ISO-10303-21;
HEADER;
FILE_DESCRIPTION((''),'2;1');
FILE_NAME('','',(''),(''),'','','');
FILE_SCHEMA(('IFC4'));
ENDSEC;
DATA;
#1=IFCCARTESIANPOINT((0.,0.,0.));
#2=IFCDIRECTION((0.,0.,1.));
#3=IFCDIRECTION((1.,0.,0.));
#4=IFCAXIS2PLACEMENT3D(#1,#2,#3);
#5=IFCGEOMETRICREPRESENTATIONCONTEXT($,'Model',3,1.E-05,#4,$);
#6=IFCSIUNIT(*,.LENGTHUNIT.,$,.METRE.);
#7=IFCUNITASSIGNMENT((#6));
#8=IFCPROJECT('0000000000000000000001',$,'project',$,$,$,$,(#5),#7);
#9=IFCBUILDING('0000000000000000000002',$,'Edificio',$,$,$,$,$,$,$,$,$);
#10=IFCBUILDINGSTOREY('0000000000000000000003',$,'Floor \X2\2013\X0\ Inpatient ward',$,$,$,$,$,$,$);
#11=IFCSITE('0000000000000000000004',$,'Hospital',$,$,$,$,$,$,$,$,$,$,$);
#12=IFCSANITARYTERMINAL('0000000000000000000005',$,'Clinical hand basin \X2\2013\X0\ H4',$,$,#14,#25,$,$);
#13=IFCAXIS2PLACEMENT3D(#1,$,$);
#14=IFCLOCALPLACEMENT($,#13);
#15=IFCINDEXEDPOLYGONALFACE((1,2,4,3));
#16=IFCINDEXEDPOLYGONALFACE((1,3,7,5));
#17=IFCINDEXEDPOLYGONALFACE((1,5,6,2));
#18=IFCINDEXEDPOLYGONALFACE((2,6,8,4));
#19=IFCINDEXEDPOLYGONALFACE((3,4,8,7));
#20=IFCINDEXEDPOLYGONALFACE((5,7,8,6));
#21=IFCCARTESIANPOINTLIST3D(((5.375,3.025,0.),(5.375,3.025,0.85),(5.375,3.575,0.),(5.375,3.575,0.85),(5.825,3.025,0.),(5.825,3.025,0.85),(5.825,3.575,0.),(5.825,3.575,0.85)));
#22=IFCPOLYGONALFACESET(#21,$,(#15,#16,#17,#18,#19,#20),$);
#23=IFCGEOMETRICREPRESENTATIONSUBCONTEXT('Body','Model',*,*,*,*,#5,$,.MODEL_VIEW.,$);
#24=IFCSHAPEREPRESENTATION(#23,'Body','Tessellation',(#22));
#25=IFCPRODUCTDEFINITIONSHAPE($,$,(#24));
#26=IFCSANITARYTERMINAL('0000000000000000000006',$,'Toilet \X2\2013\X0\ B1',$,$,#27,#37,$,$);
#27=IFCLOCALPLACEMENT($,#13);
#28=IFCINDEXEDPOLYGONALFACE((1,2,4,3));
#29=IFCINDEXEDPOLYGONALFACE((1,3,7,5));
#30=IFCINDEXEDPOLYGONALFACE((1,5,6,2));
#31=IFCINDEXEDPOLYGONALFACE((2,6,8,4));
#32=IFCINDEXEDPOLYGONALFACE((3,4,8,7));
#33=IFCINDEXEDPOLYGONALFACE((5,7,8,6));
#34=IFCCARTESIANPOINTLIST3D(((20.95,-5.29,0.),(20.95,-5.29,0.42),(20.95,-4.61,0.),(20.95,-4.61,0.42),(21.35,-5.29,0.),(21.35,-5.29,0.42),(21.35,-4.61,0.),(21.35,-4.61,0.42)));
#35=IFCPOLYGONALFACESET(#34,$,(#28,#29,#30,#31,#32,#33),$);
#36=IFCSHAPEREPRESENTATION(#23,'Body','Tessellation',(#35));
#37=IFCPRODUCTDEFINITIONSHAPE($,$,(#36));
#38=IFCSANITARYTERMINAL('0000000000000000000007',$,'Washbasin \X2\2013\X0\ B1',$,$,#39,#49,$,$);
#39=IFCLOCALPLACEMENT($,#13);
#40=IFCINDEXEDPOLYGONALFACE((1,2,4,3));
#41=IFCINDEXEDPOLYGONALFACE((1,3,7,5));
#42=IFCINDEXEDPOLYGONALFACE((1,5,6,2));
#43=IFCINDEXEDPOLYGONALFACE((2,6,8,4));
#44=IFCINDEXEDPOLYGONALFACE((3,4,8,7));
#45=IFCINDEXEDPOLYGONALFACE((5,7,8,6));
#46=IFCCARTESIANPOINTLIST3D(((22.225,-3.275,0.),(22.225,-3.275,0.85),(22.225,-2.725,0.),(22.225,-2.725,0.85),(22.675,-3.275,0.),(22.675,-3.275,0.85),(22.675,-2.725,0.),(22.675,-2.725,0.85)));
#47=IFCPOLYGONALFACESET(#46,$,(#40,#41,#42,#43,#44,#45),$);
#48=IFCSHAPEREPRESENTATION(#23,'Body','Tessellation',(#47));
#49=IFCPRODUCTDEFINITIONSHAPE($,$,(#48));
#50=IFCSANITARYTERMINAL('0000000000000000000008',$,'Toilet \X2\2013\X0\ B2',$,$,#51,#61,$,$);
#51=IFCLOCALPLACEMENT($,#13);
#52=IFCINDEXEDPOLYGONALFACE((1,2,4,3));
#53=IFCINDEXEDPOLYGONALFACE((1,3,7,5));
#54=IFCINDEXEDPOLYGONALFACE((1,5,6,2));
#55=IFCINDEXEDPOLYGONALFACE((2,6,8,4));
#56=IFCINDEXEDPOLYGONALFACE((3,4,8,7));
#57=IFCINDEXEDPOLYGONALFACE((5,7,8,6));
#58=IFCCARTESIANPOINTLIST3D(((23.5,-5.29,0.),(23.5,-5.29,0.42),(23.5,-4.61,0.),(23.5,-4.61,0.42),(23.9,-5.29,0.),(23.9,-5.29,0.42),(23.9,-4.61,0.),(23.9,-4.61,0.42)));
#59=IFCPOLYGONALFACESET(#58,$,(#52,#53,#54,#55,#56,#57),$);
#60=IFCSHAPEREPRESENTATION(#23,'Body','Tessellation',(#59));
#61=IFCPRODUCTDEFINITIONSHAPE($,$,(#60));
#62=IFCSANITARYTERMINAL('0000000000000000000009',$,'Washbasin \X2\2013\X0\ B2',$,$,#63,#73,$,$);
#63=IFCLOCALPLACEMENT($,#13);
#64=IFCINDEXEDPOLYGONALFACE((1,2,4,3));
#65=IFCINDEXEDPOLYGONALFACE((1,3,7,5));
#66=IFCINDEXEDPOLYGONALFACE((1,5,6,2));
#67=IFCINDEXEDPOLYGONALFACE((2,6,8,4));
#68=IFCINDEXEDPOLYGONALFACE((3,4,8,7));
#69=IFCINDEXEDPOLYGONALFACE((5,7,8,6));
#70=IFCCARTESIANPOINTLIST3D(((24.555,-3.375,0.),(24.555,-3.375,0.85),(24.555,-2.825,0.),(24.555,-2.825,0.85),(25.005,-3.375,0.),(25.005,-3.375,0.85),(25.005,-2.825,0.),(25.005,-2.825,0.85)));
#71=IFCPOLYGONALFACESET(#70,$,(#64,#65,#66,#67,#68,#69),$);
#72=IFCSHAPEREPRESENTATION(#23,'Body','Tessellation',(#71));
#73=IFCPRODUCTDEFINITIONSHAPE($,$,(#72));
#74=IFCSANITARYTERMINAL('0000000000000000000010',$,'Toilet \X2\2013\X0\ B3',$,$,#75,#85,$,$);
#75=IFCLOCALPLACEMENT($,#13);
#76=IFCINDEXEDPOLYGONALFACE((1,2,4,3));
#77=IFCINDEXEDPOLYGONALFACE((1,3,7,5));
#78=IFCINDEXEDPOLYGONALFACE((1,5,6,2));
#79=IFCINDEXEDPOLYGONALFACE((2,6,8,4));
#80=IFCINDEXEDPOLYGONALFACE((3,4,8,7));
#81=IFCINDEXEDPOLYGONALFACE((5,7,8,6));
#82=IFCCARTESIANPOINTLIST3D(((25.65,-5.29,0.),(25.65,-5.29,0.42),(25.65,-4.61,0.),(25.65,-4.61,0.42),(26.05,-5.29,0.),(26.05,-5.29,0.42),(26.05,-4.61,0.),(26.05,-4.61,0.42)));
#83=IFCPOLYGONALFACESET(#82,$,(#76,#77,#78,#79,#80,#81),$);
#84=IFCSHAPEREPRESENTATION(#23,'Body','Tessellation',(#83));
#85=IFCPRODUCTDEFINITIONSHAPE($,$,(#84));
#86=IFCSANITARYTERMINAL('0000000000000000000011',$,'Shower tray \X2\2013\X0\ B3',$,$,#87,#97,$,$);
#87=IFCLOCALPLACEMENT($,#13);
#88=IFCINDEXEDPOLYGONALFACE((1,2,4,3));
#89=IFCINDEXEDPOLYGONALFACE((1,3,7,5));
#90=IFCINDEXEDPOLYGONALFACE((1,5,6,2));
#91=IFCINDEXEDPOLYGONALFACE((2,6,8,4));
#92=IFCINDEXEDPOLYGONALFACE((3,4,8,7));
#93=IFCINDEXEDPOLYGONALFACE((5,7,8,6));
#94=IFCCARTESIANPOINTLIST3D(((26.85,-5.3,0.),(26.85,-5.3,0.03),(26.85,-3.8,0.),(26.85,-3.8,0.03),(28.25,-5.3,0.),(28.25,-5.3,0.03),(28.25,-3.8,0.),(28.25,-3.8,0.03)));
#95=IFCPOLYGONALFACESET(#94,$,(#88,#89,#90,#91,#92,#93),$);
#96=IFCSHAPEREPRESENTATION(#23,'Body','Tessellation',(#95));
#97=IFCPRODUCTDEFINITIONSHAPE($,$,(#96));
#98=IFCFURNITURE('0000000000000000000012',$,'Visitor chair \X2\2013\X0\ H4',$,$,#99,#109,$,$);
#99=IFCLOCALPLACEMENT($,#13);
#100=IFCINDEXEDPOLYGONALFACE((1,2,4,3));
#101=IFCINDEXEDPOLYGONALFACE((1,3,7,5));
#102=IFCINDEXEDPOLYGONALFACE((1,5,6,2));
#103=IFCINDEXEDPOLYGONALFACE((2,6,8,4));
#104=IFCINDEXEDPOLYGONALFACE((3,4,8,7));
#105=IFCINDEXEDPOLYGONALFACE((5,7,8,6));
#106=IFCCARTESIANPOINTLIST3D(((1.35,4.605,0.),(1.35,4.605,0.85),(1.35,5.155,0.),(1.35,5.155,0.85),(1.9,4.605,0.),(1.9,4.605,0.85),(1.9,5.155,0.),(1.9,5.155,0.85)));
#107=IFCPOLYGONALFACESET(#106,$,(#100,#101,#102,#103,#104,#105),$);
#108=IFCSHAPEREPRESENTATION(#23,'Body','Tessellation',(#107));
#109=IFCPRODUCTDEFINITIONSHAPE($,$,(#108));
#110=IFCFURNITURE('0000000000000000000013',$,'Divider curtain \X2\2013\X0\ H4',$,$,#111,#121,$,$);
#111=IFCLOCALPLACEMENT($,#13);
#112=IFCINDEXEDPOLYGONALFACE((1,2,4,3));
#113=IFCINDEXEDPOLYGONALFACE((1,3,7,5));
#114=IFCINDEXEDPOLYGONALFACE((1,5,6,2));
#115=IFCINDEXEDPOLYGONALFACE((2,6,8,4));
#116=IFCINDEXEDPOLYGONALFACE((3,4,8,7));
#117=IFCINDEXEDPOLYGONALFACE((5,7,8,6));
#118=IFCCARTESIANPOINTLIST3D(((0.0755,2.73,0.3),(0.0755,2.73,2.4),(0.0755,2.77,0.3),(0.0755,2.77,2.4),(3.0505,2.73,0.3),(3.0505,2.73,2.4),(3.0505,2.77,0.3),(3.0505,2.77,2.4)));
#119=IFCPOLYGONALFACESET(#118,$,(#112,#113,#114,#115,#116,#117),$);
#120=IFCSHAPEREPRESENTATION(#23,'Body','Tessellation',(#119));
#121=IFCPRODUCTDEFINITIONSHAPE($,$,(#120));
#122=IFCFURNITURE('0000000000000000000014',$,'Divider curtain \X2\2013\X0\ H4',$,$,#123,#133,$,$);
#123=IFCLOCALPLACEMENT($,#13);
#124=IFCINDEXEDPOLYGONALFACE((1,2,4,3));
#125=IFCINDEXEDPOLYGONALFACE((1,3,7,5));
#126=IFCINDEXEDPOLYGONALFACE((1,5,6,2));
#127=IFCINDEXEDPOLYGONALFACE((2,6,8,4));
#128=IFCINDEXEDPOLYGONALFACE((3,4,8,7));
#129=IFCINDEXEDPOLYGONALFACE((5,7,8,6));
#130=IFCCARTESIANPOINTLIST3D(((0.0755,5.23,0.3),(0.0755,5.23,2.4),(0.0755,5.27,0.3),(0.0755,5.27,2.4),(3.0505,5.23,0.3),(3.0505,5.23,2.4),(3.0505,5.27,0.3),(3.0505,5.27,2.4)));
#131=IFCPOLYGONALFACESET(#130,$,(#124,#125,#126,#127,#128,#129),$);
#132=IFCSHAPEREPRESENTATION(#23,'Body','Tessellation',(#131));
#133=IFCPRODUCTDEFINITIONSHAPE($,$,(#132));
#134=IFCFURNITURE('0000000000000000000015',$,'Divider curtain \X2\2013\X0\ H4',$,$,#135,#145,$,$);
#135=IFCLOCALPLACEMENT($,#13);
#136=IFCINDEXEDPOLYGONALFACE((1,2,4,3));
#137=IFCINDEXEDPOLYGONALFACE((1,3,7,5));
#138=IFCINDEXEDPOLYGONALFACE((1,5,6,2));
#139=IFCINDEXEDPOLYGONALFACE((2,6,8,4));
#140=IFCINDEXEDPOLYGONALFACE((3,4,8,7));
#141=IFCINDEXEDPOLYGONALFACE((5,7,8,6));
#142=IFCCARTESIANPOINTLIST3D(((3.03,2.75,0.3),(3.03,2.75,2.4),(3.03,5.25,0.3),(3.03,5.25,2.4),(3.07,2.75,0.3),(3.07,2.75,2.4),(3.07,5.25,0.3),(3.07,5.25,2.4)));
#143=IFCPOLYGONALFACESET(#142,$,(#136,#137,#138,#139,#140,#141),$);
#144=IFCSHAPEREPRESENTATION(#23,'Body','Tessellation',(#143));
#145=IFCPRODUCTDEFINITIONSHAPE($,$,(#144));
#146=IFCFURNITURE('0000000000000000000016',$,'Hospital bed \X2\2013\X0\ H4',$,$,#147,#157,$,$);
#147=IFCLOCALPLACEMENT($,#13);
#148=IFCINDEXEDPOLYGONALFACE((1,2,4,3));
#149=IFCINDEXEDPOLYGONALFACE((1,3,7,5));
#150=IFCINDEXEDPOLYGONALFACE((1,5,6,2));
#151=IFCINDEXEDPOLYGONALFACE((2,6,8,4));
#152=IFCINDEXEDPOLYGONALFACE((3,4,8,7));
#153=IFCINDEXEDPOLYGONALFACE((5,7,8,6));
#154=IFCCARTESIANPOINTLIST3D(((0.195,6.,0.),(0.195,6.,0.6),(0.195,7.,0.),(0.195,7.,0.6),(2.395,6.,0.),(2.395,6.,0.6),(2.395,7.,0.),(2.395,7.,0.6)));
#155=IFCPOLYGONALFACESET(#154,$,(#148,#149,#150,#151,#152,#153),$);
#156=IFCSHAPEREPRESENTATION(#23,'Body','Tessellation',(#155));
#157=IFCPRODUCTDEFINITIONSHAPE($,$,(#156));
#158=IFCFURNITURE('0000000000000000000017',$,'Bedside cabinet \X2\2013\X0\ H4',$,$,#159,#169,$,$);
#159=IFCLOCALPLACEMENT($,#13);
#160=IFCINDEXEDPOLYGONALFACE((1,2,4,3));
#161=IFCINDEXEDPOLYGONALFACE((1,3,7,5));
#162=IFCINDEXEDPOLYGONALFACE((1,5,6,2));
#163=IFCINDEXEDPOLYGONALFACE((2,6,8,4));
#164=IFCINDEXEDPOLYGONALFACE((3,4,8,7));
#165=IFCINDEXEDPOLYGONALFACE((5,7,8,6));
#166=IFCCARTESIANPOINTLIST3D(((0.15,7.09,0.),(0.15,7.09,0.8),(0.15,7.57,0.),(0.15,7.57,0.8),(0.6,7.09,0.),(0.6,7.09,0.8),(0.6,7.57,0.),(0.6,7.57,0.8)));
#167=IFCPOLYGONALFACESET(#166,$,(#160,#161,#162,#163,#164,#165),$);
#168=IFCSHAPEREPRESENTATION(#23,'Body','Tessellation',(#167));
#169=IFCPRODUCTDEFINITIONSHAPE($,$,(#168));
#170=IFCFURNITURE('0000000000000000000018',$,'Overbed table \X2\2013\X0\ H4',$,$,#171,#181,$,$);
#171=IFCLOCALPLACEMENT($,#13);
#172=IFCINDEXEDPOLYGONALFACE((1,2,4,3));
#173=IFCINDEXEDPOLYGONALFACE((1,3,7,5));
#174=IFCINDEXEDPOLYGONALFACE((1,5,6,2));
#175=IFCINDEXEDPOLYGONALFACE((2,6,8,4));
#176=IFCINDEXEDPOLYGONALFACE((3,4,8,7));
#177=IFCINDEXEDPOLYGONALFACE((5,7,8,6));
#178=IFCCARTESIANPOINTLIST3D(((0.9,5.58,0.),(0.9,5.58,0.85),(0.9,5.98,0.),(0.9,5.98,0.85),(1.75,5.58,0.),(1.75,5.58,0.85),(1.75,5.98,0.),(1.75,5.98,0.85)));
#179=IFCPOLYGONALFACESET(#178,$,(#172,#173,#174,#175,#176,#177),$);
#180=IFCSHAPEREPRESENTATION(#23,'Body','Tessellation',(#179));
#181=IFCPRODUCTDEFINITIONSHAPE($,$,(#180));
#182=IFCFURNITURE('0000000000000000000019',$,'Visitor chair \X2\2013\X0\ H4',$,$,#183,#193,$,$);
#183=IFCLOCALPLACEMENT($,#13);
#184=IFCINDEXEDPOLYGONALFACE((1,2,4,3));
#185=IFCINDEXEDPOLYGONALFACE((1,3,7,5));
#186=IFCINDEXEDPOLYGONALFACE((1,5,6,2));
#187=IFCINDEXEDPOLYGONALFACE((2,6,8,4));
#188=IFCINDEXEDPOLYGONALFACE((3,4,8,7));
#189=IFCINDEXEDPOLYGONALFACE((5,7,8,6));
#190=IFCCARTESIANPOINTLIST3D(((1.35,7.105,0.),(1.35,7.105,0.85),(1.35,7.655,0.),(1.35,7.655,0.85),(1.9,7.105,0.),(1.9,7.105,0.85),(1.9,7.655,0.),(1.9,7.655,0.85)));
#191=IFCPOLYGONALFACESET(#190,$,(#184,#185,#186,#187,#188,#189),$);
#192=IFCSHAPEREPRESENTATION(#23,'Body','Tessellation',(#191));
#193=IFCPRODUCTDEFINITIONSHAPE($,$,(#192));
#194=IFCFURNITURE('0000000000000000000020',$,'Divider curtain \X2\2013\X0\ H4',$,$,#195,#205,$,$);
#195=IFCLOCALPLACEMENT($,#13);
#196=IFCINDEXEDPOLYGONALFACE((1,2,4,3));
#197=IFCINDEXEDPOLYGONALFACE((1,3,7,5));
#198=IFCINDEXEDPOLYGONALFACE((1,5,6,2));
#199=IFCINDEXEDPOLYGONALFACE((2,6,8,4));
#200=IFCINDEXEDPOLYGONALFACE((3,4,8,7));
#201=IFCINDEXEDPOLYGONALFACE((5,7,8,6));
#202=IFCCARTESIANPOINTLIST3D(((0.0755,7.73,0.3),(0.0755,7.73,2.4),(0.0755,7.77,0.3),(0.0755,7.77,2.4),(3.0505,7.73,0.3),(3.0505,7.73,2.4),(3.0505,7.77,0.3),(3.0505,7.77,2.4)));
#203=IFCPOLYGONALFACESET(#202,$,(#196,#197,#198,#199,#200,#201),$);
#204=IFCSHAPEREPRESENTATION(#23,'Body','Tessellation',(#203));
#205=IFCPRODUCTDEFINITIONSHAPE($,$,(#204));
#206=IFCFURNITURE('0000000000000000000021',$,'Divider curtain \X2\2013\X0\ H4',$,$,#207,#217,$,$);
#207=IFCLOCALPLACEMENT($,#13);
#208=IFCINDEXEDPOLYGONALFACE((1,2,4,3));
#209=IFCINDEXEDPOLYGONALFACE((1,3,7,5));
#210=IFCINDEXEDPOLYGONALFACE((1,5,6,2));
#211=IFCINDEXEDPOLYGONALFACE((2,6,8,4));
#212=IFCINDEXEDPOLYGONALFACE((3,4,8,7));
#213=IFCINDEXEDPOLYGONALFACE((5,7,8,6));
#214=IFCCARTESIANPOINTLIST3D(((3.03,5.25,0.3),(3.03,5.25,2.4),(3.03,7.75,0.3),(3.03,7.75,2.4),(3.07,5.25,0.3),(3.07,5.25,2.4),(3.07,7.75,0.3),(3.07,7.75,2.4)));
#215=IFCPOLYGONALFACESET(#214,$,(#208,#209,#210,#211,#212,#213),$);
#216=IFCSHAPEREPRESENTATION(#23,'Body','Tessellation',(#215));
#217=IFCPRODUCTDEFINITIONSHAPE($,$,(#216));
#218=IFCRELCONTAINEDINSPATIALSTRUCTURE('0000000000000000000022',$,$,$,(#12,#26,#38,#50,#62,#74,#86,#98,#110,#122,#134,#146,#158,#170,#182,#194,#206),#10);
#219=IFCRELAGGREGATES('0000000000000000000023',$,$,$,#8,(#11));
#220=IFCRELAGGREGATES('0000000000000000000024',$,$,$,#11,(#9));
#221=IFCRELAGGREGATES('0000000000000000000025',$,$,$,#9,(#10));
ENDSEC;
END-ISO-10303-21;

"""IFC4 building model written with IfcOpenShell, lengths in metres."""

from ifc_helpers import new_model, si_unit, frame, origin_with_axes, context, subcontext, project, spatial, line, indexed_curve, outline, extrude, element, save


model = new_model("IFC4")

# Units and contexts
model_context = context("Model", 3, precision=1e-05, world=origin_with_axes())
body_context = subcontext(model_context, "Body", "Model", "MODEL_VIEW")
ifc_project = project(units=[si_unit("LENGTHUNIT", "METRE")], contexts=[model_context])

# Site, building, storey
site = spatial("IfcSite", under=ifc_project, Name="Hospital")
building = spatial("IfcBuilding", under=site, Name="Edificio")
storey = spatial("IfcBuildingStorey", under=building, Name="Floor – Inpatient ward")

# Sanitary terminals
element("IfcSanitaryTerminal", 1, inside=storey, Name="Clinical hand basin – H4", context=body_context, shape_type="SweptSolid", body=[
    extrude(outline(indexed_curve([(0.0, 0.0), (0.45, 0.0), (0.45, 0.55), (0.0, 0.55)], segments=[line(1, 2, 3, 4, 1)])), frame((5.375, 3.025, 0.0), z_axis=(0.0, 0.0, 1.0), x_axis=(1.0, 0.0, 0.0)), (0.0, 0.0, 1.0), 0.85),
])
element("IfcSanitaryTerminal", 2, inside=storey, Name="Toilet – B1", context=body_context, shape_type="SweptSolid", body=[
    extrude(outline(indexed_curve([(0.0, 0.0), (0.4, 0.0), (0.4, 0.68), (0.0, 0.68)], segments=[line(1, 2, 3, 4, 1)])), frame((20.95, -5.29, 0.0), z_axis=(0.0, 0.0, 1.0), x_axis=(1.0, 0.0, 0.0)), (0.0, 0.0, 1.0), 0.42),
])
element("IfcSanitaryTerminal", 3, inside=storey, Name="Washbasin – B1", context=body_context, shape_type="SweptSolid", body=[
    extrude(outline(indexed_curve([(0.0, 0.0), (0.45, 0.0), (0.45, 0.55), (0.0, 0.55)], segments=[line(1, 2, 3, 4, 1)])), frame((22.225, -3.275, 0.0), z_axis=(0.0, 0.0, 1.0), x_axis=(1.0, 0.0, 0.0)), (0.0, 0.0, 1.0), 0.85),
])
element("IfcSanitaryTerminal", 4, inside=storey, Name="Toilet – B2", context=body_context, shape_type="SweptSolid", body=[
    extrude(outline(indexed_curve([(0.0, 0.0), (0.4, 0.0), (0.4, 0.68), (0.0, 0.68)], segments=[line(1, 2, 3, 4, 1)])), frame((23.5, -5.29, 0.0), z_axis=(0.0, 0.0, 1.0), x_axis=(1.0, 0.0, 0.0)), (0.0, 0.0, 1.0), 0.42),
])
element("IfcSanitaryTerminal", 5, inside=storey, Name="Washbasin – B2", context=body_context, shape_type="SweptSolid", body=[
    extrude(outline(indexed_curve([(0.0, 0.0), (0.45, 0.0), (0.45, 0.55), (0.0, 0.55)], segments=[line(1, 2, 3, 4, 1)])), frame((24.555, -3.375, 0.0), z_axis=(0.0, 0.0, 1.0), x_axis=(1.0, 0.0, 0.0)), (0.0, 0.0, 1.0), 0.85),
])
element("IfcSanitaryTerminal", 6, inside=storey, Name="Toilet – B3", context=body_context, shape_type="SweptSolid", body=[
    extrude(outline(indexed_curve([(0.0, 0.0), (0.4, 0.0), (0.4, 0.68), (0.0, 0.68)], segments=[line(1, 2, 3, 4, 1)])), frame((25.65, -5.29, 0.0), z_axis=(0.0, 0.0, 1.0), x_axis=(1.0, 0.0, 0.0)), (0.0, 0.0, 1.0), 0.42),
])
element("IfcSanitaryTerminal", 7, inside=storey, Name="Shower tray – B3", context=body_context, shape_type="SweptSolid", body=[
    extrude(outline(indexed_curve([(0.0, 0.0), (1.4, 0.0), (1.4, 1.5), (0.0, 1.5)], segments=[line(1, 2, 3, 4, 1)])), frame((26.85, -5.3, 0.0), z_axis=(0.0, 0.0, 1.0), x_axis=(1.0, 0.0, 0.0)), (0.0, 0.0, 1.0), 0.03),
])

# Furniture
element("IfcFurniture", 8, inside=storey, Name="Visitor chair – H4", context=body_context, shape_type="SweptSolid", body=[
    extrude(outline(indexed_curve([(0.0, 0.0), (0.55, 0.0), (0.55, 0.55), (0.0, 0.55)], segments=[line(1, 2, 3, 4, 1)])), frame((1.35, 4.605, 0.0), z_axis=(0.0, 0.0, 1.0), x_axis=(1.0, 0.0, 0.0)), (0.0, 0.0, 1.0), 0.85),
])
element("IfcFurniture", 9, inside=storey, Name="Divider curtain – H4", context=body_context, shape_type="SweptSolid", body=[
    extrude(outline(indexed_curve([(0.0, 0.0), (2.975, 0.0), (2.975, 0.04), (0.0, 0.04)], segments=[line(1, 2, 3, 4, 1)])), frame((0.0755, 2.73, 0.3), z_axis=(0.0, 0.0, 1.0), x_axis=(1.0, 0.0, 0.0)), (0.0, 0.0, 1.0), 2.1),
])
element("IfcFurniture", 10, inside=storey, Name="Divider curtain – H4", context=body_context, shape_type="SweptSolid", body=[
    extrude(outline(indexed_curve([(0.0, 0.0), (2.975, 0.0), (2.975, 0.04), (0.0, 0.04)], segments=[line(1, 2, 3, 4, 1)])), frame((0.0755, 5.23, 0.3), z_axis=(0.0, 0.0, 1.0), x_axis=(1.0, 0.0, 0.0)), (0.0, 0.0, 1.0), 2.1),
])
element("IfcFurniture", 11, inside=storey, Name="Divider curtain – H4", context=body_context, shape_type="SweptSolid", body=[
    extrude(outline(indexed_curve([(0.0, 0.0), (0.04, 0.0), (0.04, 2.5), (0.0, 2.5)], segments=[line(1, 2, 3, 4, 1)])), frame((3.03, 2.75, 0.3), z_axis=(0.0, 0.0, 1.0), x_axis=(1.0, 0.0, 0.0)), (0.0, 0.0, 1.0), 2.1),
])
element("IfcFurniture", 12, inside=storey, Name="Hospital bed – H4", context=body_context, shape_type="SweptSolid", body=[
    extrude(outline(indexed_curve([(0.0, 0.0), (2.2, 0.0), (2.2, 1.0), (0.0, 1.0)], segments=[line(1, 2, 3, 4, 1)])), frame((0.195, 6.0, 0.0), z_axis=(0.0, 0.0, 1.0), x_axis=(1.0, 0.0, 0.0)), (0.0, 0.0, 1.0), 0.6),
])
element("IfcFurniture", 13, inside=storey, Name="Bedside cabinet – H4", context=body_context, shape_type="SweptSolid", body=[
    extrude(outline(indexed_curve([(0.0, 0.0), (0.45, 0.0), (0.45, 0.48), (0.0, 0.48)], segments=[line(1, 2, 3, 4, 1)])), frame((0.15, 7.09, 0.0), z_axis=(0.0, 0.0, 1.0), x_axis=(1.0, 0.0, 0.0)), (0.0, 0.0, 1.0), 0.8),
])
element("IfcFurniture", 14, inside=storey, Name="Overbed table – H4", context=body_context, shape_type="SweptSolid", body=[
    extrude(outline(indexed_curve([(0.0, 0.0), (0.85, 0.0), (0.85, 0.4), (0.0, 0.4)], segments=[line(1, 2, 3, 4, 1)])), frame((0.9, 5.58, 0.0), z_axis=(0.0, 0.0, 1.0), x_axis=(1.0, 0.0, 0.0)), (0.0, 0.0, 1.0), 0.85),
])
element("IfcFurniture", 15, inside=storey, Name="Visitor chair – H4", context=body_context, shape_type="SweptSolid", body=[
    extrude(outline(indexed_curve([(0.0, 0.0), (0.55, 0.0), (0.55, 0.55), (0.0, 0.55)], segments=[line(1, 2, 3, 4, 1)])), frame((1.35, 7.105, 0.0), z_axis=(0.0, 0.0, 1.0), x_axis=(1.0, 0.0, 0.0)), (0.0, 0.0, 1.0), 0.85),
])
element("IfcFurniture", 16, inside=storey, Name="Divider curtain – H4", context=body_context, shape_type="SweptSolid", body=[
    extrude(outline(indexed_curve([(0.0, 0.0), (2.975, 0.0), (2.975, 0.04), (0.0, 0.04)], segments=[line(1, 2, 3, 4, 1)])), frame((0.0755, 7.73, 0.3), z_axis=(0.0, 0.0, 1.0), x_axis=(1.0, 0.0, 0.0)), (0.0, 0.0, 1.0), 2.1),
])
element("IfcFurniture", 17, inside=storey, Name="Divider curtain – H4", context=body_context, shape_type="SweptSolid", body=[
    extrude(outline(indexed_curve([(0.0, 0.0), (0.04, 0.0), (0.04, 2.5), (0.0, 2.5)], segments=[line(1, 2, 3, 4, 1)])), frame((3.03, 5.25, 0.3), z_axis=(0.0, 0.0, 1.0), x_axis=(1.0, 0.0, 0.0)), (0.0, 0.0, 1.0), 2.1),
])

save(model, "model.ifc")
